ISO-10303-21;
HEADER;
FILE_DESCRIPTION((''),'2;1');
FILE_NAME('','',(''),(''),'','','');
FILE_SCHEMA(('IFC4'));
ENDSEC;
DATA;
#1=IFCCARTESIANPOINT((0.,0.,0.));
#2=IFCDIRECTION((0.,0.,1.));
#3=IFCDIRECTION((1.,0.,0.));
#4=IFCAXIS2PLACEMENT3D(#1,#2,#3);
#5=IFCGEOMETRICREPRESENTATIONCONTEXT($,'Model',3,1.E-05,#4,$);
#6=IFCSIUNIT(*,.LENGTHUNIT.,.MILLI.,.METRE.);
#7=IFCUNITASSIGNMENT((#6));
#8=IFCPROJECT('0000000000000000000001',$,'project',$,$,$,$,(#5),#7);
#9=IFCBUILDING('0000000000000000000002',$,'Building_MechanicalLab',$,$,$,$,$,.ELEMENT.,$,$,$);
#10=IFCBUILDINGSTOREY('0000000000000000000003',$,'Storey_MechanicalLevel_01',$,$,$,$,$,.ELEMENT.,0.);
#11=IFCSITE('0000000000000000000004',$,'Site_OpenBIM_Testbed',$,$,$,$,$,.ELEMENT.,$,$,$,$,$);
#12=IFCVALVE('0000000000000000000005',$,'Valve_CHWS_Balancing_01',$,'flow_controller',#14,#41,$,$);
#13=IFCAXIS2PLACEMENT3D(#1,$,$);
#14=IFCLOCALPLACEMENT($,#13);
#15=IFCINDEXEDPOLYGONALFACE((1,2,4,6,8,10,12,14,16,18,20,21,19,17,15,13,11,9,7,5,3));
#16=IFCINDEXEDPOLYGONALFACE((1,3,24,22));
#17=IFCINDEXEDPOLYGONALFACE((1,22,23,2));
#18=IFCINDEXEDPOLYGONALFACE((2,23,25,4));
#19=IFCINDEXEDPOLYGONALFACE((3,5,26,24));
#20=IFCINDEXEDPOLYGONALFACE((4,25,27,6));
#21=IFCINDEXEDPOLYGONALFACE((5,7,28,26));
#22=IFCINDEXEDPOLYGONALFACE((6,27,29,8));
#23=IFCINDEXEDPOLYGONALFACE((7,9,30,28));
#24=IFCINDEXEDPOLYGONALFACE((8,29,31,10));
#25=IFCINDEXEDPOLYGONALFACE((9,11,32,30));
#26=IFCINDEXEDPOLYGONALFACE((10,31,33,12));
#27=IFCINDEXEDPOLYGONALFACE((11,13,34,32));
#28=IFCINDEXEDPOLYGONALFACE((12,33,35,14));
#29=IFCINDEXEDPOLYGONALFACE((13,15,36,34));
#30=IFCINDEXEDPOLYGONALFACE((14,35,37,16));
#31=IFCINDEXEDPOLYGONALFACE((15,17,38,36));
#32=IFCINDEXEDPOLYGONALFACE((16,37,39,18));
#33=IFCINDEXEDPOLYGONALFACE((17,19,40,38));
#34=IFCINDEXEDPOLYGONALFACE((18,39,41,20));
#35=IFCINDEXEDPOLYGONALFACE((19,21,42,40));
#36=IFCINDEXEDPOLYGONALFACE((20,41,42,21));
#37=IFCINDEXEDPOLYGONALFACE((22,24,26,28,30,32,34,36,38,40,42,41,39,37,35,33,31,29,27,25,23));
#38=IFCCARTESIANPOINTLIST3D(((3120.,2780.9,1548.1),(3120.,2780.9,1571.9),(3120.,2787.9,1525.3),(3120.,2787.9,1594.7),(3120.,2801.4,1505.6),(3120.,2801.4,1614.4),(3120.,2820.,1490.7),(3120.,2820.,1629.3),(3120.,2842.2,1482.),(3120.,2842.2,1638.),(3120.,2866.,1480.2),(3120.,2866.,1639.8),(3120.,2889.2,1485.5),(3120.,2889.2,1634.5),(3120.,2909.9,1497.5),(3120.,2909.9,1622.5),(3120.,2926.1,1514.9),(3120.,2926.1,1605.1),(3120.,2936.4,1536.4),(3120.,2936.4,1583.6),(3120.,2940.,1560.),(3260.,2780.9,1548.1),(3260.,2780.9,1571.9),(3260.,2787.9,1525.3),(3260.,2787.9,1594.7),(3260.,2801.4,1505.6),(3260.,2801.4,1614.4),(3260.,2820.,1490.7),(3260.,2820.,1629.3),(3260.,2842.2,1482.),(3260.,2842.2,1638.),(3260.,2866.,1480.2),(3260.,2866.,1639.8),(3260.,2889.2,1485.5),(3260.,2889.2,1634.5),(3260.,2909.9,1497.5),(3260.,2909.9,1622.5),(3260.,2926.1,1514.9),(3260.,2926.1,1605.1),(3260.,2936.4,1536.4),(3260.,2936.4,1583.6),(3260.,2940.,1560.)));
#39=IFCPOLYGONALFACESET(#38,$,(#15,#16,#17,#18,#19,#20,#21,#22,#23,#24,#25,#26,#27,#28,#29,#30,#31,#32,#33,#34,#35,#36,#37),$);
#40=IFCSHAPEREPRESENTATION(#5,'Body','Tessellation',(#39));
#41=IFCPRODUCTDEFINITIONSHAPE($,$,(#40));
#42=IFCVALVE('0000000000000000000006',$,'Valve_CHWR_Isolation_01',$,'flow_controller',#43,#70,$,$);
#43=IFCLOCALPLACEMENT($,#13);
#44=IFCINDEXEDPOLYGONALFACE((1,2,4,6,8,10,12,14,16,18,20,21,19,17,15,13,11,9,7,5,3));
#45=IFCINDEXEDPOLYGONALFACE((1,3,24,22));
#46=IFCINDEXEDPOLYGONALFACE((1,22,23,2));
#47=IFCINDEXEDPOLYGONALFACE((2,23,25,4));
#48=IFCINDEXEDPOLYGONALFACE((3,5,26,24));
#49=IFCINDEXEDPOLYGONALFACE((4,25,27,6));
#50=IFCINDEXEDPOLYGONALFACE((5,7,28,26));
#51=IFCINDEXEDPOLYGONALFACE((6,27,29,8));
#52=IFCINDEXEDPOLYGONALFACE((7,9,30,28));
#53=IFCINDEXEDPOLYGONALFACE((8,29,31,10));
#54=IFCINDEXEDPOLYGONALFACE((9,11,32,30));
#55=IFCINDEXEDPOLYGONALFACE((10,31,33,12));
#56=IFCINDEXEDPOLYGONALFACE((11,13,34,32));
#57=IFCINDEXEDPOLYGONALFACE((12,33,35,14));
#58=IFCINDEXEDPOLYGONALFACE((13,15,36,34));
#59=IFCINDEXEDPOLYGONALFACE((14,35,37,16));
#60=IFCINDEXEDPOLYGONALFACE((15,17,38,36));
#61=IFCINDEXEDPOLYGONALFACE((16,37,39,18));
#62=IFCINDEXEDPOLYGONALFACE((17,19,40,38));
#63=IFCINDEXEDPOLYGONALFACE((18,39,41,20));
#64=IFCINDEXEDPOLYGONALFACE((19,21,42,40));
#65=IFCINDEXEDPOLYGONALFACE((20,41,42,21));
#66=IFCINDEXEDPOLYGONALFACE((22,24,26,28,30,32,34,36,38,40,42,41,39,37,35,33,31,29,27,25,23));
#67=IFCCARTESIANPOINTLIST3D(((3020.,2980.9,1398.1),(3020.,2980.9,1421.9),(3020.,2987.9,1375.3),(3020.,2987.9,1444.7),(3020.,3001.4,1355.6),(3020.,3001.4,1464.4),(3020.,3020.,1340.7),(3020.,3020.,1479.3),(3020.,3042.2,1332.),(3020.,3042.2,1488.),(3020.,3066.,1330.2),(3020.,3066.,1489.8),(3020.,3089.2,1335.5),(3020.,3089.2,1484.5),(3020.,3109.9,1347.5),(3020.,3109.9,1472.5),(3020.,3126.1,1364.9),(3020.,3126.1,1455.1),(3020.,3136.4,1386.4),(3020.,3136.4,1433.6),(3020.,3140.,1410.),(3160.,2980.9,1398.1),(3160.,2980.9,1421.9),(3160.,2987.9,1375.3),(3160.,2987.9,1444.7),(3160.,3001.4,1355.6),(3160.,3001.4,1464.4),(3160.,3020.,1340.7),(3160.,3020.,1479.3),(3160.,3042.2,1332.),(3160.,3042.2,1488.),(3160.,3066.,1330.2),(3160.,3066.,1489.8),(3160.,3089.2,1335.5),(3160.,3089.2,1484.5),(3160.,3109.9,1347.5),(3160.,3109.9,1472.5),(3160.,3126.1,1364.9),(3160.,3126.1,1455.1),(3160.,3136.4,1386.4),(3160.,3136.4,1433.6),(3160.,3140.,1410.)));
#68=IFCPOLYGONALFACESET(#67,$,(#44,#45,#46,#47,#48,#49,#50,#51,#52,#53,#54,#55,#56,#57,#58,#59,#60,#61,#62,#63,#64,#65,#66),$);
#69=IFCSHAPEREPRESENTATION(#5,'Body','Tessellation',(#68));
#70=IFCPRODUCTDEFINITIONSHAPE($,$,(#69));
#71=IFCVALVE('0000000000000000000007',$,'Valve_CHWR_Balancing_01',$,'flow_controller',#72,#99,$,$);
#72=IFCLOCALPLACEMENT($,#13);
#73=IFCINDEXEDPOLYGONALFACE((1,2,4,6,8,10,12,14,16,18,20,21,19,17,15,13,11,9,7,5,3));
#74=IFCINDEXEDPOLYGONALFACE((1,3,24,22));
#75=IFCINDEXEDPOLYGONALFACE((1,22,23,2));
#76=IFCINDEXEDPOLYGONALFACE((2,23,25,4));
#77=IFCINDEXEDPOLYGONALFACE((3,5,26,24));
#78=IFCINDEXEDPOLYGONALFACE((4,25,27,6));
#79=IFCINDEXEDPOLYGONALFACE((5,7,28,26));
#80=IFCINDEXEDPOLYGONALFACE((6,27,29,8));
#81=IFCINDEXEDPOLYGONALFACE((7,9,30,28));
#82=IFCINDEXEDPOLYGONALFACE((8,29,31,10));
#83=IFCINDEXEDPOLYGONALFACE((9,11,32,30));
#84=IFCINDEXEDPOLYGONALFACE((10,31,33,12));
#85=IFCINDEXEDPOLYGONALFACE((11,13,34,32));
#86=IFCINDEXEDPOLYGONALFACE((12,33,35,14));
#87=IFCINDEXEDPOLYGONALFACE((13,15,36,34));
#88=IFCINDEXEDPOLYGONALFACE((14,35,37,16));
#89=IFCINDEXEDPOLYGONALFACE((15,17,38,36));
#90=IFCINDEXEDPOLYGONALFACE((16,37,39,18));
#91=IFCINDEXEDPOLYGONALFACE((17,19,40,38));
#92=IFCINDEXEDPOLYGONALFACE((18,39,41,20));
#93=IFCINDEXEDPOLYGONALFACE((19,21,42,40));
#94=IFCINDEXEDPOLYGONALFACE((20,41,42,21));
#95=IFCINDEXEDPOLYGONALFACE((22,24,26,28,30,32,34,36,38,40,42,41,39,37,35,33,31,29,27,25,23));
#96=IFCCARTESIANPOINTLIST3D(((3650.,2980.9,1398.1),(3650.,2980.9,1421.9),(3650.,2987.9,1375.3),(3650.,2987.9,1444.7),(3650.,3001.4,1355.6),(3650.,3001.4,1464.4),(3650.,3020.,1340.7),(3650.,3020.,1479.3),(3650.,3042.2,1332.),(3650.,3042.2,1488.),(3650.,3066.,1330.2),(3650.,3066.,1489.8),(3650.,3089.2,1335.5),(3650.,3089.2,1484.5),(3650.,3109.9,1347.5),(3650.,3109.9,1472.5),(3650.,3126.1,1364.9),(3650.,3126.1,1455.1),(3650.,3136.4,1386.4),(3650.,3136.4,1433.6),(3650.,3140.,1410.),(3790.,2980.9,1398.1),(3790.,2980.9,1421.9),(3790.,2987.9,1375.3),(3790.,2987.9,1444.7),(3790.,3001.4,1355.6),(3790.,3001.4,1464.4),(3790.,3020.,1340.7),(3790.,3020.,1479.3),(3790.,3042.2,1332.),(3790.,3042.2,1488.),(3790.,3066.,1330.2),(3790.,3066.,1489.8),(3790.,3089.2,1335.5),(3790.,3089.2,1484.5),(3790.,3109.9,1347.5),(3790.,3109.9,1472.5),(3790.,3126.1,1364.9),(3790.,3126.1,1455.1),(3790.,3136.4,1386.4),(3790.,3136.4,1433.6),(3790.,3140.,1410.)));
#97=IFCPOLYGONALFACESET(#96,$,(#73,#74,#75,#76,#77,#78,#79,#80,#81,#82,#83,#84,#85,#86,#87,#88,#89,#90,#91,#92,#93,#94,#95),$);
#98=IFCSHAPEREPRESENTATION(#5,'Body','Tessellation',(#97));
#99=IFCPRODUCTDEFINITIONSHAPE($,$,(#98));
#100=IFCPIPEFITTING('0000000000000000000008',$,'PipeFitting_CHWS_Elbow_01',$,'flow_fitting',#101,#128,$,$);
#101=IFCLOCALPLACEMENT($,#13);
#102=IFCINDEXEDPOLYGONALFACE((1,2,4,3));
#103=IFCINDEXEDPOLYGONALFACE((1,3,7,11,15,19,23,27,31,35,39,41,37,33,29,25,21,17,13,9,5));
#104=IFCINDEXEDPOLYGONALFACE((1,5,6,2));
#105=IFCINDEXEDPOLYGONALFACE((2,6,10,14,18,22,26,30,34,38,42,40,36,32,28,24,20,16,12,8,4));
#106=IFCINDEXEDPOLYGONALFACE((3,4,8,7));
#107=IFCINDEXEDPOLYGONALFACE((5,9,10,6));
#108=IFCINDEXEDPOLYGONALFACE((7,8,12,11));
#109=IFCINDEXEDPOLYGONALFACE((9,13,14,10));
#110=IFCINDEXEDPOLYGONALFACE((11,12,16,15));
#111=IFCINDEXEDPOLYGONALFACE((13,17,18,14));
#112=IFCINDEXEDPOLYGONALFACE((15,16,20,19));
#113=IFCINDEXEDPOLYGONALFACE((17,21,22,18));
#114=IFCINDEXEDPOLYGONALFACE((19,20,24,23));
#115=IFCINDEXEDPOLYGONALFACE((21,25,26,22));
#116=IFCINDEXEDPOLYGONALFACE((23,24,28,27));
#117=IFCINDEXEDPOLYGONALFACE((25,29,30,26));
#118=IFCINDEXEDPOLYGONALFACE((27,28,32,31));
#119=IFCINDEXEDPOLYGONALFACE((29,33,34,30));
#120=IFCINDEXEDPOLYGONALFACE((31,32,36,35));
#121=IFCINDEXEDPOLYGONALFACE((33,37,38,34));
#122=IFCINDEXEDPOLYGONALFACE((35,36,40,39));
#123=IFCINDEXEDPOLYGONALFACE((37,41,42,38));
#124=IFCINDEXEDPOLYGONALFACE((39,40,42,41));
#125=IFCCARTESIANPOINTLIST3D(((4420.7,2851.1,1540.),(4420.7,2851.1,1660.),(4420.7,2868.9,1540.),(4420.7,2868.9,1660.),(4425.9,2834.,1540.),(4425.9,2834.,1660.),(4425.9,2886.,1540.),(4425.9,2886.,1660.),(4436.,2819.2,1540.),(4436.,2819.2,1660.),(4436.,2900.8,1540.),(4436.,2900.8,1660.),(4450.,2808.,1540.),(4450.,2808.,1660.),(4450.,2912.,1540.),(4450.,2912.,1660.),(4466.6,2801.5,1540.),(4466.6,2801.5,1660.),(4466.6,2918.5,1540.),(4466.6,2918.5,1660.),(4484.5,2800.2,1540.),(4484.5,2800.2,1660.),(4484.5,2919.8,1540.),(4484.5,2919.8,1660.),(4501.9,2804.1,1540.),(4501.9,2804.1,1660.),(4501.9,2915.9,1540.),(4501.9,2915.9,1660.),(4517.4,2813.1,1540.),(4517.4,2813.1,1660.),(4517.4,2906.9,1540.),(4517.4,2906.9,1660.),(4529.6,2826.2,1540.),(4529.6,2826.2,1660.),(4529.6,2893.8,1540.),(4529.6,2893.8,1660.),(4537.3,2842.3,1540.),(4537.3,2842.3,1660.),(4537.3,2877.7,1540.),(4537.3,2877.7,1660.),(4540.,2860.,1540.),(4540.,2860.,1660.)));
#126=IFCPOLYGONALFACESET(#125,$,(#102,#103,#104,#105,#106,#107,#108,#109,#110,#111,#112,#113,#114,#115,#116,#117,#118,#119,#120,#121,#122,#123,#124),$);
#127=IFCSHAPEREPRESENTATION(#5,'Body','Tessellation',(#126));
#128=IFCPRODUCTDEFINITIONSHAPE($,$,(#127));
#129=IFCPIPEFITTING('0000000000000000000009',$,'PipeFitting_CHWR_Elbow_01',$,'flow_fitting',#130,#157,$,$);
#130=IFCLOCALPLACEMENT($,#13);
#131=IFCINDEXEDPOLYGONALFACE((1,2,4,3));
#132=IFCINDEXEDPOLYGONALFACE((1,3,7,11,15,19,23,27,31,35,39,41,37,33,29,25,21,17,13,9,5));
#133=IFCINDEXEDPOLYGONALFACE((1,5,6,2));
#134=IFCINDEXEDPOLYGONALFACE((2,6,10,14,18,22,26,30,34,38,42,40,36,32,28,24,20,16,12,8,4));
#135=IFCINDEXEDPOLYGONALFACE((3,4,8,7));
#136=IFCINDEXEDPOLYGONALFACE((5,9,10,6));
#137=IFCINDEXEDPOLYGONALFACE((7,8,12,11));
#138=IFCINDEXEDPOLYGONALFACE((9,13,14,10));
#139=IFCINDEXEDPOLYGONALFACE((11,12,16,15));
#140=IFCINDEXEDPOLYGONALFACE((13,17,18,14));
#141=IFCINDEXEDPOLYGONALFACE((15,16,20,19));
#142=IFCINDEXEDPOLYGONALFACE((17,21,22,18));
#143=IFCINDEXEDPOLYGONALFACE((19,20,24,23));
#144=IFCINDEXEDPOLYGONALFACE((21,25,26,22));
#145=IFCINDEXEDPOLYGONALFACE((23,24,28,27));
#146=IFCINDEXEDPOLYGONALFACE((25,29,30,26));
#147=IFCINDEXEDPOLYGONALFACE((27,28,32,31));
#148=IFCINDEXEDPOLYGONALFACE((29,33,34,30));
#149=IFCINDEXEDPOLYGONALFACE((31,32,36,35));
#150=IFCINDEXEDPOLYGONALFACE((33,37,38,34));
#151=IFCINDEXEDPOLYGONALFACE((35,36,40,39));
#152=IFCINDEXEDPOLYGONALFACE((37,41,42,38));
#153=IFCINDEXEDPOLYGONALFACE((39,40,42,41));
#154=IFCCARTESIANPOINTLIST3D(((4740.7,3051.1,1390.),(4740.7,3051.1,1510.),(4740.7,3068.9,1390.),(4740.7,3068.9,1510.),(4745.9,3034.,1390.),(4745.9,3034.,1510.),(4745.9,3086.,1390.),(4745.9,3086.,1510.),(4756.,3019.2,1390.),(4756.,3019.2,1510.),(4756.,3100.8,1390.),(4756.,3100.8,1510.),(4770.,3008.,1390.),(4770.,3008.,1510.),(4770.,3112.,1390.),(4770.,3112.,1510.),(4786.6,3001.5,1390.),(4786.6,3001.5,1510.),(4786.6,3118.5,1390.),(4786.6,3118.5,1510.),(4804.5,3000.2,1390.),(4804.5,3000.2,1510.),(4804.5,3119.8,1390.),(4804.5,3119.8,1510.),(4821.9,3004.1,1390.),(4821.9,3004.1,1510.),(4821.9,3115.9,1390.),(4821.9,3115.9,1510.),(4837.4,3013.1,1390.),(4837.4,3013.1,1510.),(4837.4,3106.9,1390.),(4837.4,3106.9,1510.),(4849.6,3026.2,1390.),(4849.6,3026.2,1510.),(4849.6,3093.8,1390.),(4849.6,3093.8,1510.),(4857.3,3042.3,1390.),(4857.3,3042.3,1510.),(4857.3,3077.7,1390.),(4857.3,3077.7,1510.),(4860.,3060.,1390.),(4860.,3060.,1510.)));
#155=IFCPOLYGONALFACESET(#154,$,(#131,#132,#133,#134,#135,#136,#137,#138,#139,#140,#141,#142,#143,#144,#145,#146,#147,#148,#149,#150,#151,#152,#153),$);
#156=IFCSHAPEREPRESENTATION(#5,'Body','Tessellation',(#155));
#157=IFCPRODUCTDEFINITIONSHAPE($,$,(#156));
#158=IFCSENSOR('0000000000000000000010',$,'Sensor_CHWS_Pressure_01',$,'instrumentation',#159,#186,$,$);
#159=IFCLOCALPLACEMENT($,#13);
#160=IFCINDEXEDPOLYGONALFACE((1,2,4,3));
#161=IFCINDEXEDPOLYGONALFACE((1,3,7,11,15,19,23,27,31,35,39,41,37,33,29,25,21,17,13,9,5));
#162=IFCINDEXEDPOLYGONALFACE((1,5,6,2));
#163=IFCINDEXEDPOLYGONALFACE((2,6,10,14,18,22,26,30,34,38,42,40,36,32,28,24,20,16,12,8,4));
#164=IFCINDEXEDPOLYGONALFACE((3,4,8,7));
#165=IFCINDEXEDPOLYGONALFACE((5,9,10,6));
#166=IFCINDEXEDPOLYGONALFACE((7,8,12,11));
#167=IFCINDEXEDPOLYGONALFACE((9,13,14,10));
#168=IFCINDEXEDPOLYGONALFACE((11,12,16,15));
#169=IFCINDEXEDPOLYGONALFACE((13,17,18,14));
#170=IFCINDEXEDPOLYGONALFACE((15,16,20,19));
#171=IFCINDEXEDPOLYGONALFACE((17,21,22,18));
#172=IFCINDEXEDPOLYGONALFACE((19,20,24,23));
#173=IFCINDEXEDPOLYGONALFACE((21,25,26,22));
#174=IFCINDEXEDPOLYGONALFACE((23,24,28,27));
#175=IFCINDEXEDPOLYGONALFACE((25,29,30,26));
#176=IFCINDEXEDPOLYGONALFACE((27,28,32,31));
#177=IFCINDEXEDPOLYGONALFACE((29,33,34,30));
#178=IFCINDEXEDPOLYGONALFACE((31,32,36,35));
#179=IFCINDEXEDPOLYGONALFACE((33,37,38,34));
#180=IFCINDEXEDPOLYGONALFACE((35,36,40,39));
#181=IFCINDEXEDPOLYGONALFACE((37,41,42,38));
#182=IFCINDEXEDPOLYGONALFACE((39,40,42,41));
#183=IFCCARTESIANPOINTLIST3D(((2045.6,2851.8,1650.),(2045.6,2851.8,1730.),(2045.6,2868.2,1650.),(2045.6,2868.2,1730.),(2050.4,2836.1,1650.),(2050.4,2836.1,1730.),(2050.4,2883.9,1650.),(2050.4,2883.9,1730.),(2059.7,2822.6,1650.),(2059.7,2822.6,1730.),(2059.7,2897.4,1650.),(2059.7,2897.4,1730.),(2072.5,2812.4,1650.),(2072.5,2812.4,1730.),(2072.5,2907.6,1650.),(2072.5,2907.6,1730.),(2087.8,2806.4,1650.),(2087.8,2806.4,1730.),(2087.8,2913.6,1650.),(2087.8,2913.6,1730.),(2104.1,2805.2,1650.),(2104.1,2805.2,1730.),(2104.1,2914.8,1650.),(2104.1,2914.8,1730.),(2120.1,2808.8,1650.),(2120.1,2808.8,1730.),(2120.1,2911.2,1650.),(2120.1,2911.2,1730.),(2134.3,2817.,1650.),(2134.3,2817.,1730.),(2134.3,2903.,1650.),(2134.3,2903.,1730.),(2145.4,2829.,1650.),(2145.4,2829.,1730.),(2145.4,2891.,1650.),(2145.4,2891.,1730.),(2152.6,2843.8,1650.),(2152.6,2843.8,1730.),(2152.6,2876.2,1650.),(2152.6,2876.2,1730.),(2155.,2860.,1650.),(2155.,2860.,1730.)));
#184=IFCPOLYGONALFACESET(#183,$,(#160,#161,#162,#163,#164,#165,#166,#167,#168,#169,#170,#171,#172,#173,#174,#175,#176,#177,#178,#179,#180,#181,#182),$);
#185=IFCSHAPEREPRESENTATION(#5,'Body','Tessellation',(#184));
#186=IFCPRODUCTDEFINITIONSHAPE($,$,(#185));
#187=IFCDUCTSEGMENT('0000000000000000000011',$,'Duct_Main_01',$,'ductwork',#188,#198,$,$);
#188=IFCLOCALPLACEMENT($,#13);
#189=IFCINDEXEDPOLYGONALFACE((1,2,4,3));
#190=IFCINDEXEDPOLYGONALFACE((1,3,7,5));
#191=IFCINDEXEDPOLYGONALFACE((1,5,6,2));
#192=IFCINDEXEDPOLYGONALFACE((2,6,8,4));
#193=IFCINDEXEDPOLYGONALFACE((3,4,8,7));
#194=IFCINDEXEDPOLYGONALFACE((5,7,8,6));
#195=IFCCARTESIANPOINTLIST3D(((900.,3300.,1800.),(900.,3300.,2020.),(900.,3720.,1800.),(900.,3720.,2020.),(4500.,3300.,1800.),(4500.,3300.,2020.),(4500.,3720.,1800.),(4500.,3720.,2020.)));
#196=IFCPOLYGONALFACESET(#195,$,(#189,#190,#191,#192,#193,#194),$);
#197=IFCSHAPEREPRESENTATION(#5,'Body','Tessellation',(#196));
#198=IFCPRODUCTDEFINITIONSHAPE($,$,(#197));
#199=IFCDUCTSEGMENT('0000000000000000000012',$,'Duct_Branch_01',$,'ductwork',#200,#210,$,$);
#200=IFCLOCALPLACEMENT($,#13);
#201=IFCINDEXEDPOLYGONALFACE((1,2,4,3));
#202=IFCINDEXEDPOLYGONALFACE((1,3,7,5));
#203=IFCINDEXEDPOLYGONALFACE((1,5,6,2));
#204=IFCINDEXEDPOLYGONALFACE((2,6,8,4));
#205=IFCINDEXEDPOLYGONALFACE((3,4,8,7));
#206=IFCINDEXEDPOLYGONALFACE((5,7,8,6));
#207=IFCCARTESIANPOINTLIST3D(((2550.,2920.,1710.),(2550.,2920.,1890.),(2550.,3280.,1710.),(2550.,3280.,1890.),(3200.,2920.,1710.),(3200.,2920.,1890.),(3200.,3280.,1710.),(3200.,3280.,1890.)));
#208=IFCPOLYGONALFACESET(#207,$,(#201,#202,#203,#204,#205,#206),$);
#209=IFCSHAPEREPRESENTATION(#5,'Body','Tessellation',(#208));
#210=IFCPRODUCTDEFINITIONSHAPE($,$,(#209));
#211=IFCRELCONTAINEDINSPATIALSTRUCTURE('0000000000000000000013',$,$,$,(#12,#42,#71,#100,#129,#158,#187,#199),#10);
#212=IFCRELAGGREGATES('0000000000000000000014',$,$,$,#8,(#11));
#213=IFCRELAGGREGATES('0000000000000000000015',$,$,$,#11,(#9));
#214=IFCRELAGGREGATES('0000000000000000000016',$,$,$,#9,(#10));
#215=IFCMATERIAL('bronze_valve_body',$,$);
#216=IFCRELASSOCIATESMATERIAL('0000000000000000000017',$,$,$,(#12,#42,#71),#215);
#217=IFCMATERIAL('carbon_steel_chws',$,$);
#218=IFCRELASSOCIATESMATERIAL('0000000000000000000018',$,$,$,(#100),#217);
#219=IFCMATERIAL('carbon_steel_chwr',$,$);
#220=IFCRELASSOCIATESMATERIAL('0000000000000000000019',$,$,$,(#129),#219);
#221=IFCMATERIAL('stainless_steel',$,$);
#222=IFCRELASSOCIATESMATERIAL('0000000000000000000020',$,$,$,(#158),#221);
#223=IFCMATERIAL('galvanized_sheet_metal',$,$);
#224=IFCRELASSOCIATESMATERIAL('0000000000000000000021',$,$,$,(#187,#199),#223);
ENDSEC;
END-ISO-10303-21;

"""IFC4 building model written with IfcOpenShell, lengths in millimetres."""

from ifc_helpers import new_model, si_unit, frame, origin_with_axes, place, context, project, spatial, rectangle, circle, extrude, material, element, save


model = new_model("IFC4")

# Units and contexts
model_context = context("Model", 3, precision=1e-05, world=origin_with_axes())
ifc_project = project(units=[si_unit("LENGTHUNIT", "METRE", prefix="MILLI")], contexts=[model_context])

# Site, building, storey
site = spatial("IfcSite", under=ifc_project, Name="Site_OpenBIM_Testbed", CompositionType="ELEMENT")
building = spatial("IfcBuilding", under=site, Name="Building_MechanicalLab", CompositionType="ELEMENT")
storey = spatial("IfcBuildingStorey", under=building, Name="Storey_MechanicalLevel_01", CompositionType="ELEMENT", Elevation=0.0)

# Shared definitions
ifc_material_1 = material(Name="carbon_steel_chws")
ifc_material_2 = material(Name="carbon_steel_chwr")

# Valves
ifc_material_3 = material(Name="bronze_valve_body")
for number, where, z_axis, x_axis, name in (
    (1, (3120.0, 2860.0, 1560.0), (0.0, 0.0, 1.0), (1.0, 0.0, 0.0), "Valve_CHWS_Balancing_01"),
    (2, (3020.0, 3060.0, 1410.0), (0.0, 0.0, 1.0), (1.0, 0.0, 0.0), "Valve_CHWR_Isolation_01"),
    (3, (3650.0, 3060.0, 1410.0), (0.0, 0.0, 1.0), (1.0, 0.0, 0.0), "Valve_CHWR_Balancing_01"),
):
    element("IfcValve", number, at=place(None, frame(where, z_axis=z_axis, x_axis=x_axis)), inside=storey, material=ifc_material_3, Name=name, ObjectType="flow_controller", context=model_context, shape_type="SweptSolid", body=[
        extrude(circle(Radius=80.0), frame((0.0, 0.0, 0.0), z_axis=(1.0, 0.0, 0.0), x_axis=(0.0, 1.0, 0.0)), (0.0, 0.0, 1.0), 140.0),
    ])

# Pipe fittings
pipe_fitting_1_placement = place(None, frame((4480.0, 2860.0, 1540.0), z_axis=(0.0, 0.0, 1.0), x_axis=(1.0, 0.0, 0.0)))
element("IfcPipeFitting", 4, at=pipe_fitting_1_placement, inside=storey, material=ifc_material_1, Name="PipeFitting_CHWS_Elbow_01", ObjectType="flow_fitting", context=model_context, shape_type="SweptSolid", body=[
    extrude(circle(Radius=60.0), origin_with_axes(), (0.0, 0.0, 1.0), 120.0),
])
pipe_fitting_2_placement = place(None, frame((4800.0, 3060.0, 1390.0), z_axis=(0.0, 0.0, 1.0), x_axis=(1.0, 0.0, 0.0)))
element("IfcPipeFitting", 5, at=pipe_fitting_2_placement, inside=storey, material=ifc_material_2, Name="PipeFitting_CHWR_Elbow_01", ObjectType="flow_fitting", context=model_context, shape_type="SweptSolid", body=[
    extrude(circle(Radius=60.0), origin_with_axes(), (0.0, 0.0, 1.0), 120.0),
])

# Sensor
ifc_material_4 = material(Name="stainless_steel")
sensor_placement = place(None, frame((2100.0, 2860.0, 1650.0), z_axis=(0.0, 0.0, 1.0), x_axis=(1.0, 0.0, 0.0)))
element("IfcSensor", 6, at=sensor_placement, inside=storey, material=ifc_material_4, Name="Sensor_CHWS_Pressure_01", ObjectType="instrumentation", context=model_context, shape_type="SweptSolid", body=[
    extrude(circle(Radius=55.0), origin_with_axes(), (0.0, 0.0, 1.0), 80.0),
])

# Duct segments
ifc_material_5 = material(Name="galvanized_sheet_metal")
duct_segment_1_placement = place(None, frame((900.0, 3300.0, 1800.0), z_axis=(0.0, 0.0, 1.0), x_axis=(1.0, 0.0, 0.0)))
element("IfcDuctSegment", 7, at=duct_segment_1_placement, inside=storey, material=ifc_material_5, Name="Duct_Main_01", ObjectType="ductwork", context=model_context, shape_type="SweptSolid", body=[
    extrude(rectangle(XDim=3600.0, YDim=420.0), frame((1800.0, 210.0, 0.0), z_axis=(0.0, 0.0, 1.0), x_axis=(1.0, 0.0, 0.0)), (0.0, 0.0, 1.0), 220.0),
])
duct_segment_2_placement = place(None, frame((2550.0, 2920.0, 1710.0), z_axis=(0.0, 0.0, 1.0), x_axis=(1.0, 0.0, 0.0)))
element("IfcDuctSegment", 8, at=duct_segment_2_placement, inside=storey, material=ifc_material_5, Name="Duct_Branch_01", ObjectType="ductwork", context=model_context, shape_type="SweptSolid", body=[
    extrude(rectangle(XDim=650.0, YDim=360.0), frame((325.0, 180.0, 0.0), z_axis=(0.0, 0.0, 1.0), x_axis=(1.0, 0.0, 0.0)), (0.0, 0.0, 1.0), 180.0),
])

save(model, "model.ifc")
